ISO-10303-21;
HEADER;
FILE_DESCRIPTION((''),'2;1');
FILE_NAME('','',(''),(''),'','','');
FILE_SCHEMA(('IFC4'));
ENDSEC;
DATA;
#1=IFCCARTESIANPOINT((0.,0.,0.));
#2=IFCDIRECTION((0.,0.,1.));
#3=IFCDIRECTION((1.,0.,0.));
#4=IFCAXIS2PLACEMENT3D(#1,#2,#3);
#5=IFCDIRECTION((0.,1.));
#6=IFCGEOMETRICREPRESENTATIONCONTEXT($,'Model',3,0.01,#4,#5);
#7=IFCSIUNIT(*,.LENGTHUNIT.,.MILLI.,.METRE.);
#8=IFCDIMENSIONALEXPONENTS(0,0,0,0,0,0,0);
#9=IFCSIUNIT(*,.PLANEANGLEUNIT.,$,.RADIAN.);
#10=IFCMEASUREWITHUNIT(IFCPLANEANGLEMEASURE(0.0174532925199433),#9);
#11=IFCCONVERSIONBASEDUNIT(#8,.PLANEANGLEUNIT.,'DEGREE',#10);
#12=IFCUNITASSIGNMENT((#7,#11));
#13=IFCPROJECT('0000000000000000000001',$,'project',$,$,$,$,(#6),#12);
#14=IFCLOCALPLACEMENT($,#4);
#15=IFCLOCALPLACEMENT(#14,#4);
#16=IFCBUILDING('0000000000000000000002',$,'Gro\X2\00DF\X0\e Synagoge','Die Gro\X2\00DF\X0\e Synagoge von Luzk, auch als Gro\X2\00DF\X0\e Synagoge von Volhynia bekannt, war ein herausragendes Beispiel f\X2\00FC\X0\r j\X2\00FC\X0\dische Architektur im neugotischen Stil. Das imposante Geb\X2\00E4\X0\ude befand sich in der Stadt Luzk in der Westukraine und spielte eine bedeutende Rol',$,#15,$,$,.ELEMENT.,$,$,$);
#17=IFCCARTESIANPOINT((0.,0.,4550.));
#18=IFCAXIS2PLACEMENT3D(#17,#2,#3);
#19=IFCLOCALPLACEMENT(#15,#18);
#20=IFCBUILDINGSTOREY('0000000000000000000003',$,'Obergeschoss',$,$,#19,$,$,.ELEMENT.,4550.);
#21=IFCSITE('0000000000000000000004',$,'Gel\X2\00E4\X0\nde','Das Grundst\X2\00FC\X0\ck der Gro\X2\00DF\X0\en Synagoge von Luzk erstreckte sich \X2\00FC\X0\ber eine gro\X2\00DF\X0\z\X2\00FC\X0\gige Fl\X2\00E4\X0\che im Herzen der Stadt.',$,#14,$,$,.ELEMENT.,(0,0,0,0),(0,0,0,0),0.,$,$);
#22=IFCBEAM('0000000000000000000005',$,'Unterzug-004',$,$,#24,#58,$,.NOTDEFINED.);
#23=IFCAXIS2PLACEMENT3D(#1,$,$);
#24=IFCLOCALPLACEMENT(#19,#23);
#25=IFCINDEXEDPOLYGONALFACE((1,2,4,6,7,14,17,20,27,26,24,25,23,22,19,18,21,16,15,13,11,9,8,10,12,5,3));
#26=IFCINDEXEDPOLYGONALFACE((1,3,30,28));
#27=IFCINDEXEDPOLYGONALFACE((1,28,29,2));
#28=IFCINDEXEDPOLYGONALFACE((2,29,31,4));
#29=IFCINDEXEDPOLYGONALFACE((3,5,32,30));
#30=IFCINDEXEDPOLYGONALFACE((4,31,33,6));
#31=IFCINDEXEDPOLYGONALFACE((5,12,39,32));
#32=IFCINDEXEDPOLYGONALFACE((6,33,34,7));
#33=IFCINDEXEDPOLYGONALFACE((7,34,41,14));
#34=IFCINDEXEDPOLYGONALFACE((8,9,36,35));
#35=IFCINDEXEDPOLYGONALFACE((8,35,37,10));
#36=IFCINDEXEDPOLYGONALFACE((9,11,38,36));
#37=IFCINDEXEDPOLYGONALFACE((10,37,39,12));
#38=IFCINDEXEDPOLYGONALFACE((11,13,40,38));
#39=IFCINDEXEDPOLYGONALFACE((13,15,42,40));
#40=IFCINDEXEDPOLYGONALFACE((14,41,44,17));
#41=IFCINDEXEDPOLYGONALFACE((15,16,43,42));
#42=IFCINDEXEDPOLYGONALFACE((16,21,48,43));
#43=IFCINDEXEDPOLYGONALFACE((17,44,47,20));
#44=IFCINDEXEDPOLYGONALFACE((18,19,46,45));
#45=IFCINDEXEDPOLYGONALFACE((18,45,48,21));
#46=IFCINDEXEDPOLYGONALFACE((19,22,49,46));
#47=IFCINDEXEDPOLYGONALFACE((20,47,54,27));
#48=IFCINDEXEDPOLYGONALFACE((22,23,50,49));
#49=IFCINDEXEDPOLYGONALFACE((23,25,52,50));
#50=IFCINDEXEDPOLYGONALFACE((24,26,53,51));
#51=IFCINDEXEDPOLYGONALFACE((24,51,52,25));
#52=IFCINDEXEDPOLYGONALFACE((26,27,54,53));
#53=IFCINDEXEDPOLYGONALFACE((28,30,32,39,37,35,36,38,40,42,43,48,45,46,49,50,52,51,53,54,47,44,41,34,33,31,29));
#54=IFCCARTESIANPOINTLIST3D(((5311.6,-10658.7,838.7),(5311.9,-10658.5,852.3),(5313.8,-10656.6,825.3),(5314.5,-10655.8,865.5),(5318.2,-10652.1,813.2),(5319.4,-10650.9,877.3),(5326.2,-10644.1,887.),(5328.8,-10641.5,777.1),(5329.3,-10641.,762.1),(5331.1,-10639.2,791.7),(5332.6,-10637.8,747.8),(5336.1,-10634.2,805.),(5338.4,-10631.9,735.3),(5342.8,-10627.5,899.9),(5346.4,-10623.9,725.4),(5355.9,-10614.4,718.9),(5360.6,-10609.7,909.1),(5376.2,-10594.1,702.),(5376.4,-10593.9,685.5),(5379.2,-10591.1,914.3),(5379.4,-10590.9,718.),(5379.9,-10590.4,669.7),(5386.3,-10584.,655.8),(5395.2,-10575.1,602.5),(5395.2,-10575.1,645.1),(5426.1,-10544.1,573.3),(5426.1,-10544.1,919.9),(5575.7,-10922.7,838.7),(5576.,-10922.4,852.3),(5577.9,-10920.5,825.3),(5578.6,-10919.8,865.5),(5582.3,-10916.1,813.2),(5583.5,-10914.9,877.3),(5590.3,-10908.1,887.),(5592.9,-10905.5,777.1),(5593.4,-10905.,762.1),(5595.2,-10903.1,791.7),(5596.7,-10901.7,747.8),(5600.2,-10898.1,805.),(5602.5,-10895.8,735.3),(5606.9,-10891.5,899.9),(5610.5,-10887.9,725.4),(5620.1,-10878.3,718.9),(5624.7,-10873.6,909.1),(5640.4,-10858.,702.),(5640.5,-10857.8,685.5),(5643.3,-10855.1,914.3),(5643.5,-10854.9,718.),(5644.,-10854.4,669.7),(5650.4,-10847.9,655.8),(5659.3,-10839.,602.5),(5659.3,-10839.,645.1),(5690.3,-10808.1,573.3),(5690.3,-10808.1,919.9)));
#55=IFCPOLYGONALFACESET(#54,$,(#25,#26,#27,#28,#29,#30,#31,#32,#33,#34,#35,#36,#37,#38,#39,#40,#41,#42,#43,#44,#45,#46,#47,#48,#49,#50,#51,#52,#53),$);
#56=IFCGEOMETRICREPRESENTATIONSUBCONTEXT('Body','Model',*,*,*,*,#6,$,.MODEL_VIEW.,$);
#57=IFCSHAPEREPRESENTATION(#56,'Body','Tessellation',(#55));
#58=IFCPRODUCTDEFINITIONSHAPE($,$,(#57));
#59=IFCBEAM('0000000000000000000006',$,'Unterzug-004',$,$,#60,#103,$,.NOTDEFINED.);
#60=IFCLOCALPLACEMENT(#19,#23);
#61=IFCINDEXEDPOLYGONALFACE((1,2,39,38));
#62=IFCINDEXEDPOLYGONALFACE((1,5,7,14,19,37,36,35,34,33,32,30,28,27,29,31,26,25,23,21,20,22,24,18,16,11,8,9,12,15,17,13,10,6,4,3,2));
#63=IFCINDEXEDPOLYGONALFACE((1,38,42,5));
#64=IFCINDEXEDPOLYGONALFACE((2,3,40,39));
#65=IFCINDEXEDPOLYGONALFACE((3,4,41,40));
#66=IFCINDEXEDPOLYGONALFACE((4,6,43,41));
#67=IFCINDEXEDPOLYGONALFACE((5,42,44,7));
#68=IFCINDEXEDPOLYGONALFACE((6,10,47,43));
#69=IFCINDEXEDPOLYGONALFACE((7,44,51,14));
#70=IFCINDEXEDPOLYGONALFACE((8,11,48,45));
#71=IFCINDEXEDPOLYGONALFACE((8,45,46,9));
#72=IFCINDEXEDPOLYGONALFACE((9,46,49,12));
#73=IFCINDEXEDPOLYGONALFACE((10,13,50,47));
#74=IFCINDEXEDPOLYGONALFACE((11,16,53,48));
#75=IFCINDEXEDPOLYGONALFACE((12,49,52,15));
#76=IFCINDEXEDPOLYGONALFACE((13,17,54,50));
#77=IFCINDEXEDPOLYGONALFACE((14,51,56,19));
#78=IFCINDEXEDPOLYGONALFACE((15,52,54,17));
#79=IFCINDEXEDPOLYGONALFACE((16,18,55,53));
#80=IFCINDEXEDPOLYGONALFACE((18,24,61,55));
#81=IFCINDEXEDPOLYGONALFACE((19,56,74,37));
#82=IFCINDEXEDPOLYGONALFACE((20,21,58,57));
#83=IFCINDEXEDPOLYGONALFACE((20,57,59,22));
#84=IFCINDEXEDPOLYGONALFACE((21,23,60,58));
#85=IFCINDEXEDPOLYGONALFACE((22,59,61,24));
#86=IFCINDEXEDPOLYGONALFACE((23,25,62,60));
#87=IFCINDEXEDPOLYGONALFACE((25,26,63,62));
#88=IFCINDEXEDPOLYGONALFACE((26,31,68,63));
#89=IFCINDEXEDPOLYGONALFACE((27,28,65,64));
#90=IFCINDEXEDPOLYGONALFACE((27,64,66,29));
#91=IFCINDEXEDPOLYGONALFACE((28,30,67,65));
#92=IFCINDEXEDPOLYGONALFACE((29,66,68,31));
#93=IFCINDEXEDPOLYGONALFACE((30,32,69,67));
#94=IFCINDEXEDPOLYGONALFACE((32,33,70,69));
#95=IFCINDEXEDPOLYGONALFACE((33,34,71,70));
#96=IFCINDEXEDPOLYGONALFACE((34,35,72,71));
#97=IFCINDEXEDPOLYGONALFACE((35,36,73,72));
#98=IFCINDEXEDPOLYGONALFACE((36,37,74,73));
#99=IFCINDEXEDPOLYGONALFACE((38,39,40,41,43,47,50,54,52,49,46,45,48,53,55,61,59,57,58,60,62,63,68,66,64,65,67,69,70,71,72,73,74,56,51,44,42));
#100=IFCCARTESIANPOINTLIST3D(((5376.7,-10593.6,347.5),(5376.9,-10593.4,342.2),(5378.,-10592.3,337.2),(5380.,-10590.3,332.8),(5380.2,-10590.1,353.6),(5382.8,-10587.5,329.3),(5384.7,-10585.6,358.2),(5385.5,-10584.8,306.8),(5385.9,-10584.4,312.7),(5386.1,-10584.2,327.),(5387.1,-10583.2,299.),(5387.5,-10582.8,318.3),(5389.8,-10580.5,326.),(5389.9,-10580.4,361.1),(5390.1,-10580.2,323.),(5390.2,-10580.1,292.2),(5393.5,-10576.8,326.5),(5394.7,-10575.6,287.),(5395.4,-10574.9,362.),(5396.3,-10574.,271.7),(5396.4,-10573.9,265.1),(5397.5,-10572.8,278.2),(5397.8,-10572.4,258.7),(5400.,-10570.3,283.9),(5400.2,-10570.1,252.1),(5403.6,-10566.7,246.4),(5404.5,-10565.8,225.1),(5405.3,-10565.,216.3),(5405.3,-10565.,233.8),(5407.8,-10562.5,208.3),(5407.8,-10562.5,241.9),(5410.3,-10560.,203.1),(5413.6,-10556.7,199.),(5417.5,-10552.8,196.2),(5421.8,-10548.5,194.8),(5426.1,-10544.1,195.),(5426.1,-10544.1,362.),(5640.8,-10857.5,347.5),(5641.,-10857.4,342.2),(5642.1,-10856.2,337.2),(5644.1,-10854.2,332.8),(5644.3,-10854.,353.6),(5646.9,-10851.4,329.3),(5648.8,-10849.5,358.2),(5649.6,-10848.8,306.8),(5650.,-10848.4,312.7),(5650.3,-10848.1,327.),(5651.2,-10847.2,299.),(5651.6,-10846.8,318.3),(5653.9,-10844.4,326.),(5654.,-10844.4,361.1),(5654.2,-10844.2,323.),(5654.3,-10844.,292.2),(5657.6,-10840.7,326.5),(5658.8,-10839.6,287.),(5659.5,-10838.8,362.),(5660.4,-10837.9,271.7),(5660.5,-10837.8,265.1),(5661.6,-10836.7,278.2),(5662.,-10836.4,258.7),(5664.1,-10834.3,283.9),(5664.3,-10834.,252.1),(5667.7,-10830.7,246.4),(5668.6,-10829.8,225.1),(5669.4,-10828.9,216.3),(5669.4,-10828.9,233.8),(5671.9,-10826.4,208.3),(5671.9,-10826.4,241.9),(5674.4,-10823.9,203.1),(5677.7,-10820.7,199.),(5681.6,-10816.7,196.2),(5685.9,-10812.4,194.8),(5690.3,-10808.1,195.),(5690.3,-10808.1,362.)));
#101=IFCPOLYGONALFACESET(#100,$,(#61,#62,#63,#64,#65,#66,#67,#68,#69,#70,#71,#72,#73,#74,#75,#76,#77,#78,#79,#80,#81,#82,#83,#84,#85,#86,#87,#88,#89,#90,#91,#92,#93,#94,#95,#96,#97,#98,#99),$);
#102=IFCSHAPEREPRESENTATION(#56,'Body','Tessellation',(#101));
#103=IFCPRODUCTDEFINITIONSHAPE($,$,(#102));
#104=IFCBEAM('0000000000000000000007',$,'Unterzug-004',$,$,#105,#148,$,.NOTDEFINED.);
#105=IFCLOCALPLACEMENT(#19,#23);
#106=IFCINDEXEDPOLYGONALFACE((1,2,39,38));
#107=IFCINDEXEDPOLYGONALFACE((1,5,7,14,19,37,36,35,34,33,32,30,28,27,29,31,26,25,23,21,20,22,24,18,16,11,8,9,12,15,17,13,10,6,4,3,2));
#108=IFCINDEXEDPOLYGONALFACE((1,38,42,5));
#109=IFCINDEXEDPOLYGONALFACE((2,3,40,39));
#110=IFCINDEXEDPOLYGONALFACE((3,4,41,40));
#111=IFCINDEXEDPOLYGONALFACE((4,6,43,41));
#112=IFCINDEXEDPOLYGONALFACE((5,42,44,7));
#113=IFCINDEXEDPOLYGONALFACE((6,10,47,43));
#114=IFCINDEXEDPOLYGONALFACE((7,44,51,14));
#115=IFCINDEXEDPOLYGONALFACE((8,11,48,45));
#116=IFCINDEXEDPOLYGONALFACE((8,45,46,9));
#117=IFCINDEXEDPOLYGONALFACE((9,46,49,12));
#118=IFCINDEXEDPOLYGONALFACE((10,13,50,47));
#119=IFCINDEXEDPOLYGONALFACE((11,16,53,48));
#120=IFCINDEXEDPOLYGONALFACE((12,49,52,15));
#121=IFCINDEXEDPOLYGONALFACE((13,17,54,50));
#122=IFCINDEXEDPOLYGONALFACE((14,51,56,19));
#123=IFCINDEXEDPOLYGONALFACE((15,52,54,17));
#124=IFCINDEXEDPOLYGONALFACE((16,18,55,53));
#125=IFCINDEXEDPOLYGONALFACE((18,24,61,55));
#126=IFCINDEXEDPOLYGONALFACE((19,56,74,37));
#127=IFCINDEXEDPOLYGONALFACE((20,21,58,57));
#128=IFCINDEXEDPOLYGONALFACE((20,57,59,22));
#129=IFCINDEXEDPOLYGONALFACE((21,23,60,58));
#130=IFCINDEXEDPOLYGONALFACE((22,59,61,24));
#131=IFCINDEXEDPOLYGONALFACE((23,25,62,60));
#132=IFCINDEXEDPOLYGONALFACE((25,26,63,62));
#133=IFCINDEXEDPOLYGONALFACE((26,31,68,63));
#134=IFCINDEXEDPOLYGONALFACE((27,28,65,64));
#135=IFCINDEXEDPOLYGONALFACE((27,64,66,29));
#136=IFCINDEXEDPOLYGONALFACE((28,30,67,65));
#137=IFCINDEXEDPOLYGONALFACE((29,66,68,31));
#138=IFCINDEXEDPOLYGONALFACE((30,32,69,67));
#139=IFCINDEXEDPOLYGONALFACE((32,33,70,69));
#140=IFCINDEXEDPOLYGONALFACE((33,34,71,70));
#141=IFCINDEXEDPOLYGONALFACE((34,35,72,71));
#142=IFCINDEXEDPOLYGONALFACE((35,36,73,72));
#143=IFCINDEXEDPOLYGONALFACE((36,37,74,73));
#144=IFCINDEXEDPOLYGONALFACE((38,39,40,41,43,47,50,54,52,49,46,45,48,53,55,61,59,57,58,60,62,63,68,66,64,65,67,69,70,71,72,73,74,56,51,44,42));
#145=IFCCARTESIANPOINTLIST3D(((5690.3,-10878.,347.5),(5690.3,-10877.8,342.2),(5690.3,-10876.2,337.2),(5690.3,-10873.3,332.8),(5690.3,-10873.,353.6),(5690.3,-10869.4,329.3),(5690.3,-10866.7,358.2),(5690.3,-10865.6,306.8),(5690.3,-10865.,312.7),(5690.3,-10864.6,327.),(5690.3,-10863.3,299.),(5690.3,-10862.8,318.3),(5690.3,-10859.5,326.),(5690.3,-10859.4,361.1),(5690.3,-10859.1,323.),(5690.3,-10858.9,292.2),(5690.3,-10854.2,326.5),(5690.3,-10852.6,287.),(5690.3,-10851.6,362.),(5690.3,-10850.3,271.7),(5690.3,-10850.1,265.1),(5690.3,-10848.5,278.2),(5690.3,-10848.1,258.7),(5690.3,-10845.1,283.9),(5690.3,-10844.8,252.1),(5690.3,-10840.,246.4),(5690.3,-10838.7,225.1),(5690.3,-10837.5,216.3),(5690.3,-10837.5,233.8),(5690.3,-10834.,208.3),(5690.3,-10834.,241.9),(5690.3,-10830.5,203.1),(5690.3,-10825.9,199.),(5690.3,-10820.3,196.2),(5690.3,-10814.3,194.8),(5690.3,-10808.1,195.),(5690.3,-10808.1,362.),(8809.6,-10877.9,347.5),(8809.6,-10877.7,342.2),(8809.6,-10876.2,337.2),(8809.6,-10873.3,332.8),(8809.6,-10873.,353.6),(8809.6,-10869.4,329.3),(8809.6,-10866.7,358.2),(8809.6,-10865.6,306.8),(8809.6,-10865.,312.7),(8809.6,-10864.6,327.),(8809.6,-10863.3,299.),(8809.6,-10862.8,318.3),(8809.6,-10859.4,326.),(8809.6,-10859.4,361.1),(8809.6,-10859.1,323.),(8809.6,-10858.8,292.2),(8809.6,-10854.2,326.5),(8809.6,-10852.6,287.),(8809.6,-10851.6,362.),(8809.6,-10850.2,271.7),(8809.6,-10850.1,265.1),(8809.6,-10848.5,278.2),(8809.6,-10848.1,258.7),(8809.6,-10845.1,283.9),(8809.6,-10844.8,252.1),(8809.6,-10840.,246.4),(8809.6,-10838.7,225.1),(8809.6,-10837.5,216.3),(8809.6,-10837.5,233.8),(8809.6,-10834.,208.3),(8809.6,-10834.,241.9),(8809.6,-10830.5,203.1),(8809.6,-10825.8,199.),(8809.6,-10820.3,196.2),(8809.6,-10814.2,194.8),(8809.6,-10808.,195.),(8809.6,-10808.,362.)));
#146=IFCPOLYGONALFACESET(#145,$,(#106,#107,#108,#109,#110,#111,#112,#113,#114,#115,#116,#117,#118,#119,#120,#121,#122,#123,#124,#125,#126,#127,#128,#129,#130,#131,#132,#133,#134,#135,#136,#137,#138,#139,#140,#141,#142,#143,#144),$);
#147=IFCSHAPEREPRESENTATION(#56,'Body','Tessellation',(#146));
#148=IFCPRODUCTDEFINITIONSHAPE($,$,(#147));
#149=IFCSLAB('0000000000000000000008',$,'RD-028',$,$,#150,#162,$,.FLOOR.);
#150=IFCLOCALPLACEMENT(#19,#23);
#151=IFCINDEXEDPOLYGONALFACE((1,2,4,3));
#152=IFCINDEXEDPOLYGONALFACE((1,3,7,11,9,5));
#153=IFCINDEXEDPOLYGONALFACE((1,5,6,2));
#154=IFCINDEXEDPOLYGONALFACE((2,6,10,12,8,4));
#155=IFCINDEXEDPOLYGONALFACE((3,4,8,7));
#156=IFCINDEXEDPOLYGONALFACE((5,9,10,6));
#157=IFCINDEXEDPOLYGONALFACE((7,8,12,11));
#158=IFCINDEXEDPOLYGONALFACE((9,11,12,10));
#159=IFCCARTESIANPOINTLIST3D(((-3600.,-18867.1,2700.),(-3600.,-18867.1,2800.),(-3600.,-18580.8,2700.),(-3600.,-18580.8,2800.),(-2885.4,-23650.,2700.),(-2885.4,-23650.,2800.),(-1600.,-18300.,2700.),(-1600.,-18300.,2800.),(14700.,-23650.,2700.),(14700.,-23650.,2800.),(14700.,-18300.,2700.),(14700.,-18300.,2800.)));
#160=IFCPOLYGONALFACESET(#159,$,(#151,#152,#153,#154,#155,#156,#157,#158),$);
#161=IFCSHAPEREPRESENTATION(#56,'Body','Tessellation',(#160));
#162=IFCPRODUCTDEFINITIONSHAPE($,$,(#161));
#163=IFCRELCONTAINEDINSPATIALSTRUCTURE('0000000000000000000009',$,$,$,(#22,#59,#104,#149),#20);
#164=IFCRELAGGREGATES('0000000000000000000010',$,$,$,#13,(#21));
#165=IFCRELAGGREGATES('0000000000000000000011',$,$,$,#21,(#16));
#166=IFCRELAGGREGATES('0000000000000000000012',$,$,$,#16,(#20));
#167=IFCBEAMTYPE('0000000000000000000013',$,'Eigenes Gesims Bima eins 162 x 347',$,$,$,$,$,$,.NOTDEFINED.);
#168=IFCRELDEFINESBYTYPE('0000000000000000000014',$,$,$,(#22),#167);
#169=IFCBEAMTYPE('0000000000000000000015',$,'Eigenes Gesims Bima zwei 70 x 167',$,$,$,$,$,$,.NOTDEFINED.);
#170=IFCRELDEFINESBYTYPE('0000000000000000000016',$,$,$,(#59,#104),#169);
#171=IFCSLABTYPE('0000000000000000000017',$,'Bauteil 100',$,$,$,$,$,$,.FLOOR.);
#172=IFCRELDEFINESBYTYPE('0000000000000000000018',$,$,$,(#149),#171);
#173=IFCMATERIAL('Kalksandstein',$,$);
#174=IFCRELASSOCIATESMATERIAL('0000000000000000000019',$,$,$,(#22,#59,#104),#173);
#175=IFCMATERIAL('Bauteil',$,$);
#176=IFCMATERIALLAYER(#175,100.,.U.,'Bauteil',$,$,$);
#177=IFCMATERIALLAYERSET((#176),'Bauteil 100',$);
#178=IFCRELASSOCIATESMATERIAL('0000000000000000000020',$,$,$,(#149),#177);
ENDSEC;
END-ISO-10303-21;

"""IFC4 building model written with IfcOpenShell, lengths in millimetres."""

from ifc_helpers import new_model, entity, si_unit, converted_unit, direction, frame, origin_with_axes, place, context, subcontext, project, spatial, line, arc, indexed_curve, outline, extrude, material, layer, layer_set, layer_usage, material_profile, profile_set, type_object, element, save


model = new_model("IFC4")

# Units and contexts
model_context = context("Model", 3, precision=0.01, world=origin_with_axes(), true_north=direction((0.0, 1.0)))
body_context = subcontext(model_context, "Body", "Model", "MODEL_VIEW")
ifc_project = project(units=[si_unit("LENGTHUNIT", "METRE", prefix="MILLI"), converted_unit("PLANEANGLEUNIT", "DEGREE", entity("IfcPlaneAngleMeasure", 0.0174532925199433), si_unit("PLANEANGLEUNIT", "RADIAN"), dimensions=[0, 0, 0, 0, 0, 0, 0])], contexts=[model_context])

# Site, building, storey
site_placement = place(None, origin_with_axes())
site = spatial("IfcSite", under=ifc_project, at=site_placement, Name="Gelände", Description="Das Grundstück der Großen Synagoge von Luzk erstreckte sich über eine großzügige Fläche im Herzen der Stadt.", CompositionType="ELEMENT", RefLatitude=(0, 0, 0, 0), RefLongitude=(0, 0, 0, 0), RefElevation=0.0)
building_placement = place(site_placement, origin_with_axes())
building = spatial("IfcBuilding", under=site, at=building_placement, Name="Große Synagoge", Description="Die Große Synagoge von Luzk, auch als Große Synagoge von Volhynia bekannt, war ein herausragendes Beispiel für jüdische Architektur im neugotischen Stil. Das imposante Gebäude befand sich in der Stadt Luzk in der Westukraine und spielte eine bedeutende Rol", CompositionType="ELEMENT")
storey_placement = place(building_placement, frame((0.0, 0.0, 4550.0), z_axis=(0.0, 0.0, 1.0), x_axis=(1.0, 0.0, 0.0)))
storey = spatial("IfcBuildingStorey", under=building, at=storey_placement, Name="Obergeschoss", CompositionType="ELEMENT", Elevation=4550.0)

# Beams
ifc_material_1 = material(Name="Kalksandstein")
ifc_material_profile_1 = material_profile(ifc_material_1, outline(indexed_curve([(127.4, -114.9), (152.7, -106.7), (161.7, -67.6), (141.4, -32.9), (105.5, -14.9), (66.5, -5.6), (0.0, 0.0), (0.0, -346.6), (43.7, -317.4), (43.7, -274.8), (68.5, -242.5), (66.2, -201.9), (99.3, -201.0), (135.2, -165.1)], segments=[line(1, 2), arc(2, 3, 4), arc(4, 5, 6), line(6, 7, 8, 9, 10), arc(10, 11, 12), line(12, 13), arc(13, 14, 1)])), Name="Kalksandstein")
ifc_profile_set_1 = profile_set([ifc_material_profile_1], Name="Eigenes Gesims Bima eins")
beam_type_1 = type_object("IfcBeamType", Name="Eigenes Gesims Bima eins 162 x 347", PredefinedType="NOTDEFINED")
beam_1_placement = place(storey_placement, frame((5426.1, -10544.1, 919.9), z_axis=(0.0, 0.0, 1.0), x_axis=(-0.706861, -0.707353, 0.0)))
element("IfcBeam", 1, at=beam_1_placement, inside=storey, type_object=beam_type_1, material=ifc_profile_set_1, Name="Unterzug-004", PredefinedType="NOTDEFINED", context=body_context, shape_type="SweptSolid", body=[
    extrude(outline(indexed_curve([(127.4, -114.9), (152.7, -106.7), (161.7, -67.6), (141.4, -32.9), (105.5, -14.9), (66.5, -5.6), (0.0, 0.0), (0.0, -346.6), (43.7, -317.4), (43.7, -274.8), (68.5, -242.5), (66.2, -201.9), (99.3, -201.0), (135.2, -165.1)], segments=[line(1, 2), arc(2, 3, 4), arc(4, 5, 6), line(6, 7, 8, 9, 10), arc(10, 11, 12), line(12, 13), arc(13, 14, 1)])), frame((0.0, 373.4, 0.0), z_axis=(0.0, -1.0, 0.0), x_axis=(1.0, 0.0, 0.0)), (0.0, 0.0, 1.0), 373.4),
])
ifc_material_profile_2 = material_profile(ifc_material_1, outline(indexed_curve([(40.0, -103.3), (42.2, -90.2), (37.0, -78.1), (50.8, -69.8), (57.6, -55.2), (54.7, -43.7), (46.2, -35.5), (63.4, -31.1), (69.9, -14.5), (58.6, -3.7), (43.5, 0.0), (0.0, 0.0), (0.0, -167.0), (15.1, -164.6), (26.0, -153.7), (30.7, -136.9), (26.0, -120.0), (34.5, -112.9)], segments=[arc(1, 2, 3), arc(3, 4, 5), arc(5, 6, 7), arc(7, 8, 9), arc(9, 10, 11), line(11, 12, 13), arc(13, 14, 15), arc(15, 16, 17), arc(17, 18, 1)])), Name="Kalksandstein")
ifc_profile_set_2 = profile_set([ifc_material_profile_2], Name="Eigenes Gesims Bima zwei")
beam_type_2 = type_object("IfcBeamType", Name="Eigenes Gesims Bima zwei 70 x 167", PredefinedType="NOTDEFINED")
beam_2_placement = place(storey_placement, frame((5426.1, -10544.1, 362.0), z_axis=(0.0, 0.0, 1.0), x_axis=(-0.706861, -0.707353, 0.0)))
element("IfcBeam", 2, at=beam_2_placement, inside=storey, type_object=beam_type_2, material=ifc_profile_set_2, Name="Unterzug-004", PredefinedType="NOTDEFINED", context=body_context, shape_type="SweptSolid", body=[
    extrude(outline(indexed_curve([(40.0, -103.3), (42.2, -90.2), (37.0, -78.1), (50.8, -69.8), (57.6, -55.2), (54.7, -43.7), (46.2, -35.5), (63.4, -31.1), (69.9, -14.5), (58.6, -3.7), (43.5, 0.0), (0.0, 0.0), (0.0, -167.0), (15.1, -164.6), (26.0, -153.7), (30.7, -136.9), (26.0, -120.0), (34.5, -112.9)], segments=[arc(1, 2, 3), arc(3, 4, 5), arc(5, 6, 7), arc(7, 8, 9), arc(9, 10, 11), line(11, 12, 13), arc(13, 14, 15), arc(15, 16, 17), arc(17, 18, 1)])), frame((0.0, 373.4, 0.0), z_axis=(0.0, -1.0, 0.0), x_axis=(1.0, 0.0, 0.0)), (0.0, 0.0, 1.0), 373.4),
])
beam_3_placement = place(storey_placement, frame((5690.3, -10808.1, 362.0), z_axis=(0.0, 0.0, 1.0), x_axis=(0.000006, -1.0, 0.0)))
element("IfcBeam", 3, at=beam_3_placement, inside=storey, type_object=beam_type_2, material=ifc_profile_set_2, Name="Unterzug-004", PredefinedType="NOTDEFINED", context=body_context, shape_type="SweptSolid", body=[
    extrude(outline(indexed_curve([(40.0, -103.3), (42.2, -90.2), (37.0, -78.1), (50.8, -69.8), (57.6, -55.2), (54.7, -43.7), (46.2, -35.5), (63.4, -31.1), (69.9, -14.5), (58.6, -3.7), (43.5, 0.0), (0.0, 0.0), (0.0, -167.0), (15.1, -164.6), (26.0, -153.7), (30.7, -136.9), (26.0, -120.0), (34.5, -112.9)], segments=[arc(1, 2, 3), arc(3, 4, 5), arc(5, 6, 7), arc(7, 8, 9), arc(9, 10, 11), line(11, 12, 13), arc(13, 14, 15), arc(15, 16, 17), arc(17, 18, 1)])), frame((0.0, 3119.3, 0.0), z_axis=(0.0, -1.0, 0.0), x_axis=(1.0, 0.0, 0.0)), (0.0, 0.0, 1.0), 3119.3),
])

# Slab
ifc_material_2 = material(Name="Bauteil")
ifc_layer_1 = layer(ifc_material_2, 100.0, ventilated="UNKNOWN", Name="Bauteil")
ifc_layer_set_1 = layer_set([ifc_layer_1], Name="Bauteil 100")
ifc_layer_usage_1 = layer_usage(ifc_layer_set_1, "AXIS3", "NEGATIVE", 100.0)
slab_type_1 = type_object("IfcSlabType", Name="Bauteil 100", PredefinedType="FLOOR")
slab_1_placement = place(storey_placement, frame((-2885.4, -23650.0, 2800.0), z_axis=(0.0, 0.0, 1.0), x_axis=(1.0, 0.0, 0.0)))
element("IfcSlab", 4, at=slab_1_placement, inside=storey, type_object=slab_type_1, material=ifc_layer_usage_1, Name="RD-028", PredefinedType="FLOOR", context=body_context, shape_type="SweptSolid", body=[
    extrude(outline(indexed_curve([(0.0, 0.0), (17585.4, 0.0), (17585.4, 5350.0), (1285.4, 5350.0), (-714.6, 5069.2), (-714.6, 4782.9)], segments=[line(1, 2, 3, 4, 5, 6, 1)])), frame((0.0, 0.0, -100.0), z_axis=(0.0, 0.0, 1.0), x_axis=(1.0, 0.0, 0.0)), (0.0, 0.0, 1.0), 100.0),
])

save(model, "model.ifc")
